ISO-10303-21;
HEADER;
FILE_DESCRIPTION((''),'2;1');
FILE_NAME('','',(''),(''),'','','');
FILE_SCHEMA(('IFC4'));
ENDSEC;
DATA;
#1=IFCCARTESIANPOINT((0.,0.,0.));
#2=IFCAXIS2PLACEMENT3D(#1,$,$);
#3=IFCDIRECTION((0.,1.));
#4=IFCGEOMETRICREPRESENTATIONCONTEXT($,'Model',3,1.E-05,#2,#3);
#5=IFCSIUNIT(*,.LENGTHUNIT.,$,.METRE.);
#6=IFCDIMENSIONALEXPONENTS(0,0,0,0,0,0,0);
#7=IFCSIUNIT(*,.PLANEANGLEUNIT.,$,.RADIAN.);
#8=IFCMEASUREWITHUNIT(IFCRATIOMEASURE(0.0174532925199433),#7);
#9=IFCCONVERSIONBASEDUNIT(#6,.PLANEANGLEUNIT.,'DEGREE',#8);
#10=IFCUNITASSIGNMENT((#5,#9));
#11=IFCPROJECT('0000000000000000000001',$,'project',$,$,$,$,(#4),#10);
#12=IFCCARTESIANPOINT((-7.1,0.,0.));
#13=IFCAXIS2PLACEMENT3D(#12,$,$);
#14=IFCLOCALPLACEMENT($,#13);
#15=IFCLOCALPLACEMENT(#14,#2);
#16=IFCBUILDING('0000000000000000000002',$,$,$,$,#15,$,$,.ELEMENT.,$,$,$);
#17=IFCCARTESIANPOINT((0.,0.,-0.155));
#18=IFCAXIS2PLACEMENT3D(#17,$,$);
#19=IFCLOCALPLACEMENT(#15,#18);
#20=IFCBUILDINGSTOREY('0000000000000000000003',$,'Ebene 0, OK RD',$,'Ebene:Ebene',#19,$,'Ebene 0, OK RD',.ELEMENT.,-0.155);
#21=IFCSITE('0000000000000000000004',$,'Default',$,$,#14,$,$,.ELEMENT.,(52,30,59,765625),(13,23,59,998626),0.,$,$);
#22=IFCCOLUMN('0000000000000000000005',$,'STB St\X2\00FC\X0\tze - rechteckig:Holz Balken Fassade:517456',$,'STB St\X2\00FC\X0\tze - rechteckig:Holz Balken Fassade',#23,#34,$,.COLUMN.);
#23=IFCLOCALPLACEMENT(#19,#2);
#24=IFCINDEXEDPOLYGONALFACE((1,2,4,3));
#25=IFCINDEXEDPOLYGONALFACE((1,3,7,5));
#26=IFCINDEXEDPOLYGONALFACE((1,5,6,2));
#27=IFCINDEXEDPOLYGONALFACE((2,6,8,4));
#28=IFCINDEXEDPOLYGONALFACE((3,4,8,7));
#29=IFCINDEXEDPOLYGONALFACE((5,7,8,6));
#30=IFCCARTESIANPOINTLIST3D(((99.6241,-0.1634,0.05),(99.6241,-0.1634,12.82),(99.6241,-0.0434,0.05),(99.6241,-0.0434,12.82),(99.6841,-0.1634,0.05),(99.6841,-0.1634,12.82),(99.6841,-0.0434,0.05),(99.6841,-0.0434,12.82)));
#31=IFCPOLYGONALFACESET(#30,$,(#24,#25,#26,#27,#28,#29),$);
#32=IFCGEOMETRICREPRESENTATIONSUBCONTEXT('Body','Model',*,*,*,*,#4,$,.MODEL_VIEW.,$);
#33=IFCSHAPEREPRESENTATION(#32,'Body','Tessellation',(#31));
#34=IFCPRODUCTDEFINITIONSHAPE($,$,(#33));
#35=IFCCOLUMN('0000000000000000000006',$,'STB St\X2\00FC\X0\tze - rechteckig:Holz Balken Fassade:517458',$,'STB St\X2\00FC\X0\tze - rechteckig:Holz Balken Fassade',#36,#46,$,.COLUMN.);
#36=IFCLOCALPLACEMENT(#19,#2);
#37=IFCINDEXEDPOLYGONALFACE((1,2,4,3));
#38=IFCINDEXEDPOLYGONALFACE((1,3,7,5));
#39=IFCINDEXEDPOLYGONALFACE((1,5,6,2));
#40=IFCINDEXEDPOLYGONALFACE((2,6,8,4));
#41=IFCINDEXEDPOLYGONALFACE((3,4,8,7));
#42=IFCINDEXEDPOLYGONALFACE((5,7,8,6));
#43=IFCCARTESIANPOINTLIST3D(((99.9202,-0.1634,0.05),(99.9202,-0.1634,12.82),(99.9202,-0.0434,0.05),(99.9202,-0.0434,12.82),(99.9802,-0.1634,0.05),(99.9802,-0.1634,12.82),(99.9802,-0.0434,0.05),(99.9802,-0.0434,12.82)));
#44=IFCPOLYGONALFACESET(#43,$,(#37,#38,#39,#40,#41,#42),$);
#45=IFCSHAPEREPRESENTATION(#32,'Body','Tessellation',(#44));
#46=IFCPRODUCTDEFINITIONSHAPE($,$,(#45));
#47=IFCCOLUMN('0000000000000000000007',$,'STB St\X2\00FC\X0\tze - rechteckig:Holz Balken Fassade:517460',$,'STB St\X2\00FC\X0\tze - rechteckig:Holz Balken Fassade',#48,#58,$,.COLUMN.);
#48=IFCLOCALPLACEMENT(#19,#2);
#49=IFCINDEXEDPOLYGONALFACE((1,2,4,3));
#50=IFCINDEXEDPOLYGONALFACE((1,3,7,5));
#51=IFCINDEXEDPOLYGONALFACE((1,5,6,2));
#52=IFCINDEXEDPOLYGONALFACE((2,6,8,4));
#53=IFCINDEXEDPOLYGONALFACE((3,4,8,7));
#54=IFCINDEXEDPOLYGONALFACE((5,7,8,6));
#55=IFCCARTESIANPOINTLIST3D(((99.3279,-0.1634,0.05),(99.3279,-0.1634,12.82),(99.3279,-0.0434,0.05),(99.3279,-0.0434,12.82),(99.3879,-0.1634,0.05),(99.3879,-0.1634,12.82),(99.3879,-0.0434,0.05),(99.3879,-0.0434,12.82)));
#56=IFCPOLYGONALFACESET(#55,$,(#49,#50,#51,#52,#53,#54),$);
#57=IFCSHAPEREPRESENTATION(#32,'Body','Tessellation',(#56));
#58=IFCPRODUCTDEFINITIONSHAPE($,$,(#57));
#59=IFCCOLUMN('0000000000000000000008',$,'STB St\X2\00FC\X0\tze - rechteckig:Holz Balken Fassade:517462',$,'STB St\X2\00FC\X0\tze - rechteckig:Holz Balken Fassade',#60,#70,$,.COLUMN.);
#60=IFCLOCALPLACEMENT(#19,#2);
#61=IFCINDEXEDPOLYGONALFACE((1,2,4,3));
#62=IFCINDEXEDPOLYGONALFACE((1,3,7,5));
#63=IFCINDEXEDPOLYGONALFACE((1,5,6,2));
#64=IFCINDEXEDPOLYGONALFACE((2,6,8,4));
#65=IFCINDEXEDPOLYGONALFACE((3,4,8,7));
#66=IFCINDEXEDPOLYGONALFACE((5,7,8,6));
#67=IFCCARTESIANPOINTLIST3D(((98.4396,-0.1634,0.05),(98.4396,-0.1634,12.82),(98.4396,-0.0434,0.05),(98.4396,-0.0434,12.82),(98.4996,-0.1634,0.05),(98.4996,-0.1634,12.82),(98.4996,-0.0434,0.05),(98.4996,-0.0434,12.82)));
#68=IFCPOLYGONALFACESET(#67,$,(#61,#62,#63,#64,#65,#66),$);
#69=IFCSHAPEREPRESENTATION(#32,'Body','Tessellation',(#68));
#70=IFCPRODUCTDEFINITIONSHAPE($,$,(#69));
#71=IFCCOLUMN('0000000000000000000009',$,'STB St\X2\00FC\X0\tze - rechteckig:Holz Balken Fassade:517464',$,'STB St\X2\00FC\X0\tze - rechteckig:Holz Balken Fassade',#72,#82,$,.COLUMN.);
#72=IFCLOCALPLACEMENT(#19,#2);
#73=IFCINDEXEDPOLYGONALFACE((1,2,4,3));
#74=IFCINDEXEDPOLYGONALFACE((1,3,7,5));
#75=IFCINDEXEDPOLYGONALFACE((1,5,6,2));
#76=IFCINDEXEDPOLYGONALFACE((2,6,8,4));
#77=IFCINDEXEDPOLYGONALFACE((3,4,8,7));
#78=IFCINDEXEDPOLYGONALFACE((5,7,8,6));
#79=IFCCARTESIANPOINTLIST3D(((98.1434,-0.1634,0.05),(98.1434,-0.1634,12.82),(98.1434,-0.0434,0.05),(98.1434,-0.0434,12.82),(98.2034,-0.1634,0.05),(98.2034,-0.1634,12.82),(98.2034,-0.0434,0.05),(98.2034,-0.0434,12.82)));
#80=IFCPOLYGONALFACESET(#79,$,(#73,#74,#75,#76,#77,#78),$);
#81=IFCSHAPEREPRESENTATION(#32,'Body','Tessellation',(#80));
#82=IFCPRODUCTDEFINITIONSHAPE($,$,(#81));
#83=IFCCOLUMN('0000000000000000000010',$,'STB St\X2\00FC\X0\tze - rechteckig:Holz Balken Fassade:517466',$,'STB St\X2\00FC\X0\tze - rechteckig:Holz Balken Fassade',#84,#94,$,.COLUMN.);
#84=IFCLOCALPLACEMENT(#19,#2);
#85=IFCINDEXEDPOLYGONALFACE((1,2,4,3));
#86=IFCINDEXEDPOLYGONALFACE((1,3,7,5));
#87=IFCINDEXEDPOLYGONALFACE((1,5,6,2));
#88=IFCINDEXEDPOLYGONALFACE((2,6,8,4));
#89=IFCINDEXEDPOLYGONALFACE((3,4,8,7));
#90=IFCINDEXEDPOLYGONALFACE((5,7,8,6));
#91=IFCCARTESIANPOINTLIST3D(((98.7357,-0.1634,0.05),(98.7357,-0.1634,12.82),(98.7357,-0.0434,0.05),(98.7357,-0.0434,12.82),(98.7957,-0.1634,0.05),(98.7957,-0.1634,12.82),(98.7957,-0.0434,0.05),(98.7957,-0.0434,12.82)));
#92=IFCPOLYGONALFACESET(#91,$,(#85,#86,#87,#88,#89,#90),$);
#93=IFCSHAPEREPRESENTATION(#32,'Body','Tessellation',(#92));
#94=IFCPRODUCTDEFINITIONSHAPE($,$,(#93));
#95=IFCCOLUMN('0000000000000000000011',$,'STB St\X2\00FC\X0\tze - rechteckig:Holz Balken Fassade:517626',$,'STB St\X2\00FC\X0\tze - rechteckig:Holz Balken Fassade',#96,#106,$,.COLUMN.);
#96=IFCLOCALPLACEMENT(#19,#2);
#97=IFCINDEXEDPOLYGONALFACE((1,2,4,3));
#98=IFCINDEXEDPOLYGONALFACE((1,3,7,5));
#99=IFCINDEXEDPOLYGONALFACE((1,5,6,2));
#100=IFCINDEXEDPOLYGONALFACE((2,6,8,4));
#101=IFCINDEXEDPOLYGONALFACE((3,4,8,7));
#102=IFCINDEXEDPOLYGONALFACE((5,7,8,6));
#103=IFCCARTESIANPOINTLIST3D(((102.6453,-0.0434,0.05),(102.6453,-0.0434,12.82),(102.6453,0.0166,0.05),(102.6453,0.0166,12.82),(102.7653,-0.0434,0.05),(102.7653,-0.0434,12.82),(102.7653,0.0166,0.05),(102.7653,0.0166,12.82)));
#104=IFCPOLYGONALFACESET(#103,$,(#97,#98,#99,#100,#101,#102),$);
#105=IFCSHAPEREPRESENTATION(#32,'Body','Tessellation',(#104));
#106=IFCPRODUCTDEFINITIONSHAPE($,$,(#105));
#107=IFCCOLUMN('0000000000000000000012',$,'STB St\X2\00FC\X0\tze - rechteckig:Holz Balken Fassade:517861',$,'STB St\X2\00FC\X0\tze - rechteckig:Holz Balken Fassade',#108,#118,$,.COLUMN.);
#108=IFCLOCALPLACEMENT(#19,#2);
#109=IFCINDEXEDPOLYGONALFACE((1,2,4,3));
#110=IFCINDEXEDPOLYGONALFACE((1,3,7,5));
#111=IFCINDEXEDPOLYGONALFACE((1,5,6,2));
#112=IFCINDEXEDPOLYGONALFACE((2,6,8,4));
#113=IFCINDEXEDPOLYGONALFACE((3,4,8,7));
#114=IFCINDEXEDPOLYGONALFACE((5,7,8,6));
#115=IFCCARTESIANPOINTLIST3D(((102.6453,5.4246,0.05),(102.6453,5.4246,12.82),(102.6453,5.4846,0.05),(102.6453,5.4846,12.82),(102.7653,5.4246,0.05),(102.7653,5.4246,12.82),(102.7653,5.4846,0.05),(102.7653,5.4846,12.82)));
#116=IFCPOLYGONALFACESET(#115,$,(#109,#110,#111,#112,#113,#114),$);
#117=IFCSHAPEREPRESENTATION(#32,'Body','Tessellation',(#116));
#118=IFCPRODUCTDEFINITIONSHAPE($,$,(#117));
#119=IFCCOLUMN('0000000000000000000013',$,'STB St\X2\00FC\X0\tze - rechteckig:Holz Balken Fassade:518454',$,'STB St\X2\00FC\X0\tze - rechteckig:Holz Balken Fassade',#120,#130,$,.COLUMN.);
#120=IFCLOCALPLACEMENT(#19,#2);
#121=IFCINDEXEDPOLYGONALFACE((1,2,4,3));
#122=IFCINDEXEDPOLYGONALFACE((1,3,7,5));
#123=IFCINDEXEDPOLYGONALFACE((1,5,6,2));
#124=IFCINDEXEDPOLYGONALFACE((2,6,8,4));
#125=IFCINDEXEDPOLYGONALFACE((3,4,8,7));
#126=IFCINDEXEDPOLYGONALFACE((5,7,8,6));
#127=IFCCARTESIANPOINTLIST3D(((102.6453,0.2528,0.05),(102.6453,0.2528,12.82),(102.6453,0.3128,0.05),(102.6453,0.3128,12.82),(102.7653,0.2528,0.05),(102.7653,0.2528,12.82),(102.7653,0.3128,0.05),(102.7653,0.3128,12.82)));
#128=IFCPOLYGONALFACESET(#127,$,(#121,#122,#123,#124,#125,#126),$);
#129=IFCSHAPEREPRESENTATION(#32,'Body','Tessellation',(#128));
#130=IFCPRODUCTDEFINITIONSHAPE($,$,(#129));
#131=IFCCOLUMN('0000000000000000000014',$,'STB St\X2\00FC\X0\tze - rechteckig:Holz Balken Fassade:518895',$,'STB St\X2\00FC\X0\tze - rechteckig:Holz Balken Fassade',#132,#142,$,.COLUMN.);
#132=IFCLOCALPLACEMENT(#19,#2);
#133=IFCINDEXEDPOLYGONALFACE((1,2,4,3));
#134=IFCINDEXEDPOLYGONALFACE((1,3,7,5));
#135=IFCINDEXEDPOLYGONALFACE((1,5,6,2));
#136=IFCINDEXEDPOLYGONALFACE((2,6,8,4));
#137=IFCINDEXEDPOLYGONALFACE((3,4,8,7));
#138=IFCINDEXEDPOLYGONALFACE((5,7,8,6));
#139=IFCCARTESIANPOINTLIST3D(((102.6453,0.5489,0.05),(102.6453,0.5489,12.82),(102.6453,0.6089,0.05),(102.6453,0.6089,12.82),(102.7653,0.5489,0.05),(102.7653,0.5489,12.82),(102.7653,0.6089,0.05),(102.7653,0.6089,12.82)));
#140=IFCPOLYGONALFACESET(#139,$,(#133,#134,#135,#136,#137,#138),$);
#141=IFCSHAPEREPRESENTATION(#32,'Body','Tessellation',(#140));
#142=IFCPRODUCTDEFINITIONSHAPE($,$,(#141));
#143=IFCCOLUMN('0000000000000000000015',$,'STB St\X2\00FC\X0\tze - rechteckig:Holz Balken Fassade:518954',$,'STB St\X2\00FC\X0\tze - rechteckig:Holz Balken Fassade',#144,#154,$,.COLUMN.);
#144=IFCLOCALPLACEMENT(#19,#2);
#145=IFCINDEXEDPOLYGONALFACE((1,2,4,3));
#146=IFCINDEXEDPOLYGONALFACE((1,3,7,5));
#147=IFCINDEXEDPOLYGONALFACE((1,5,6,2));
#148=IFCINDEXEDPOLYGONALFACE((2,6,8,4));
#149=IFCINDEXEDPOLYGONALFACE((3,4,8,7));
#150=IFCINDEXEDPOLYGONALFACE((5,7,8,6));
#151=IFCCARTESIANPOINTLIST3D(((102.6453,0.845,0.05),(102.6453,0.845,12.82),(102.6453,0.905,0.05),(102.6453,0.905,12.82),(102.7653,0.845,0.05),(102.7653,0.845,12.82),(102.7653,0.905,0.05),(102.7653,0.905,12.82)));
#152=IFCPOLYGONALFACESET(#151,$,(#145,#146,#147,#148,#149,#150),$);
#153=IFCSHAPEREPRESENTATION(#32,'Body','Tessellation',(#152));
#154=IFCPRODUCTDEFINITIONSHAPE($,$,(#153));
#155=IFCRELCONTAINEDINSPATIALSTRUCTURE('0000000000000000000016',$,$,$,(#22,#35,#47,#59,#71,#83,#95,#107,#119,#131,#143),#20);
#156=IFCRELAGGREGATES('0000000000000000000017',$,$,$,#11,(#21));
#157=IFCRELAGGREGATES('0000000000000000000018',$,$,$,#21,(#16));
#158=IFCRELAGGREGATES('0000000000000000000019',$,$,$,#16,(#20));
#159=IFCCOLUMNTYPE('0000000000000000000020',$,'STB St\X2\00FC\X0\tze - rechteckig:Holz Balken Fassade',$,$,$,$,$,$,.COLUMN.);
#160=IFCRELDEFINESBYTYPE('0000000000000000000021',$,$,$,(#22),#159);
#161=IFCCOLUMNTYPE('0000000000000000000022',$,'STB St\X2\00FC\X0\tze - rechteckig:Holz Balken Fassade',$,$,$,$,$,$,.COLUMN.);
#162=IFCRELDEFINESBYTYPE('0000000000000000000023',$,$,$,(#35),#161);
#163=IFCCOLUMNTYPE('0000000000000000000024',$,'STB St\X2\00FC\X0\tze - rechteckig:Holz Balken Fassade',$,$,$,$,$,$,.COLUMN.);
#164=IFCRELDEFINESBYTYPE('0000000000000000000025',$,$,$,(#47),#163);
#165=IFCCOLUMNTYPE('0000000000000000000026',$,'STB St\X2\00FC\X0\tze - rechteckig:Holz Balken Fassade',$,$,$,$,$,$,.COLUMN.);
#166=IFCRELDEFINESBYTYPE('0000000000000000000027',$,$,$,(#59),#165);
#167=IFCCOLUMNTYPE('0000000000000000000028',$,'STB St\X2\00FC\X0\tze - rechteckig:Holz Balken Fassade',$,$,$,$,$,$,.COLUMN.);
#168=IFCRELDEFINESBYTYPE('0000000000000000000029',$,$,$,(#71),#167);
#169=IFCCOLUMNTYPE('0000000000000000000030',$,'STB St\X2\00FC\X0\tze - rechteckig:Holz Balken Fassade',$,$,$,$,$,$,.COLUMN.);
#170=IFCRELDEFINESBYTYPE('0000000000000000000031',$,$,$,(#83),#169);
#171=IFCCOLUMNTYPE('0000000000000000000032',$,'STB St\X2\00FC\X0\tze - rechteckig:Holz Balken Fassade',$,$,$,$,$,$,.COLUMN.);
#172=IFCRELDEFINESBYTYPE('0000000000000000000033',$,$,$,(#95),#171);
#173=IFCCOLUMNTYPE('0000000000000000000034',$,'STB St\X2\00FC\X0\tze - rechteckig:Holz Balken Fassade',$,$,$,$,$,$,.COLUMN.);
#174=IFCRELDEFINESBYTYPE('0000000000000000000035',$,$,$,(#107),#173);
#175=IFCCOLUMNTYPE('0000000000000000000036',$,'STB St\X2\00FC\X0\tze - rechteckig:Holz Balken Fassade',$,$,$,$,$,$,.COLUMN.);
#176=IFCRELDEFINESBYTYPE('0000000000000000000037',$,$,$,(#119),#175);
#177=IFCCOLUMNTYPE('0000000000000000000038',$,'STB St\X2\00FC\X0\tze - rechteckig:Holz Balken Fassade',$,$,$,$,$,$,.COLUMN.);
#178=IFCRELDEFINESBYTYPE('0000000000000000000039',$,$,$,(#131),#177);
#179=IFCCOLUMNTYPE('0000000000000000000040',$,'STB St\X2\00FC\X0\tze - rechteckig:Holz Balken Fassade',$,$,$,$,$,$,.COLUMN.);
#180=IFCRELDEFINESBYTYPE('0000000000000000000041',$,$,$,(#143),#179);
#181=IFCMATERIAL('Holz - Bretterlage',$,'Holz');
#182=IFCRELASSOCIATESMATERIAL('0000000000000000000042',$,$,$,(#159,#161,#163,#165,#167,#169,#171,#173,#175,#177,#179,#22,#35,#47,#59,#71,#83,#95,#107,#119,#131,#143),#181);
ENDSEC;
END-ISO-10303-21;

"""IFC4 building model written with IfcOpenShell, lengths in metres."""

from ifc_helpers import new_model, entity, si_unit, converted_unit, direction, frame, frame_2d, origin, origin_2d_with_axis, place, context, subcontext, project, spatial, rectangle, extrude, source, transform, mapped, material, material_profile, profile_set, profile_usage, type_object, type_shapes, element, save


model = new_model("IFC4")

# Units and contexts
model_context = context("Model", 3, precision=1e-05, world=origin(), true_north=direction((0.0, 1.0)))
body_context = subcontext(model_context, "Body", "Model", "MODEL_VIEW")
ifc_project = project(units=[si_unit("LENGTHUNIT", "METRE"), converted_unit("PLANEANGLEUNIT", "DEGREE", entity("IfcRatioMeasure", 0.0174532925199433), si_unit("PLANEANGLEUNIT", "RADIAN"), dimensions=[0, 0, 0, 0, 0, 0, 0])], contexts=[model_context])

# Site, building, storey
site_placement = place(None, frame((-7.1, 0.0, 0.0)))
site = spatial("IfcSite", under=ifc_project, at=site_placement, Name="Default", CompositionType="ELEMENT", RefLatitude=(52, 30, 59, 765625), RefLongitude=(13, 23, 59, 998626), RefElevation=0.0)
building_placement = place(site_placement, origin())
building = spatial("IfcBuilding", under=site, at=building_placement, CompositionType="ELEMENT")
storey_placement = place(building_placement, frame((0.0, 0.0, -0.155)))
storey = spatial("IfcBuildingStorey", under=building, at=storey_placement, Name="Ebene 0, OK RD", ObjectType="Ebene:Ebene", LongName="Ebene 0, OK RD", CompositionType="ELEMENT", Elevation=-0.155)

# Columns
ifc_material = material(Name="Holz - Bretterlage", Category="Holz")
ifc_material_profile = material_profile(ifc_material, rectangle(XDim=0.12, YDim=0.06, at=frame_2d((0.0, 0.0), x_axis=(1.0, 0.0))), Name="Holz Balken Fassade")
ifc_profile_set = profile_set([ifc_material_profile], Name="Holz Balken Fassade")
ifc_profile_usage_1 = profile_usage(ifc_profile_set)
column_type_1 = type_object("IfcColumnType", Name="STB Stütze - rechteckig:Holz Balken Fassade", PredefinedType="COLUMN", material=ifc_profile_set)
shared_shape_1 = source(origin(), body_context, "Body", "SweptSolid", [
    extrude(rectangle(XDim=0.12, YDim=0.06, at=frame_2d((0.0, 0.0), x_axis=(1.0, 0.0))), frame((99.6541, -0.1034, -0.105), z_axis=(0.0, 0.0, 1.0), x_axis=(0.0, -1.0, 0.0)), (0.0, 0.0, 1.0), 12.77),
])
type_shapes(column_type_1, [shared_shape_1])
column_1_placement = place(storey_placement, frame((0.0, 0.0, 0.155)))
element("IfcColumn", 1, at=column_1_placement, inside=storey, type_object=column_type_1, material=ifc_profile_usage_1, Name="STB Stütze - rechteckig:Holz Balken Fassade:517456", ObjectType="STB Stütze - rechteckig:Holz Balken Fassade", PredefinedType="COLUMN", context=body_context, shape_type="MappedRepresentation", body=[
    mapped(shared_shape_1, transform((0.0, 0.0, 0.0), scale=1.0)),
])
ifc_profile_usage_2 = profile_usage(ifc_profile_set)
column_type_2 = type_object("IfcColumnType", Name="STB Stütze - rechteckig:Holz Balken Fassade", PredefinedType="COLUMN", material=ifc_profile_set)
shared_shape_2 = source(origin(), body_context, "Body", "SweptSolid", [
    extrude(rectangle(XDim=0.12, YDim=0.06, at=frame_2d((0.0, 0.0), x_axis=(1.0, 0.0))), frame((99.9502, -0.1034, -0.105), z_axis=(0.0, 0.0, 1.0), x_axis=(0.0, -1.0, 0.0)), (0.0, 0.0, 1.0), 12.77),
])
type_shapes(column_type_2, [shared_shape_2])
column_2_placement = place(storey_placement, frame((0.0, 0.0, 0.155)))
element("IfcColumn", 2, at=column_2_placement, inside=storey, type_object=column_type_2, material=ifc_profile_usage_2, Name="STB Stütze - rechteckig:Holz Balken Fassade:517458", ObjectType="STB Stütze - rechteckig:Holz Balken Fassade", PredefinedType="COLUMN", context=body_context, shape_type="MappedRepresentation", body=[
    mapped(shared_shape_2, transform((0.0, 0.0, 0.0), scale=1.0)),
])
ifc_profile_usage_3 = profile_usage(ifc_profile_set)
column_type_3 = type_object("IfcColumnType", Name="STB Stütze - rechteckig:Holz Balken Fassade", PredefinedType="COLUMN", material=ifc_profile_set)
shared_shape_3 = source(origin(), body_context, "Body", "SweptSolid", [
    extrude(rectangle(XDim=0.12, YDim=0.06, at=frame_2d((0.0, 0.0), x_axis=(1.0, 0.0))), frame((99.3579, -0.1034, -0.105), z_axis=(0.0, 0.0, 1.0), x_axis=(0.0, -1.0, 0.0)), (0.0, 0.0, 1.0), 12.77),
])
type_shapes(column_type_3, [shared_shape_3])
column_3_placement = place(storey_placement, frame((0.0, 0.0, 0.155)))
element("IfcColumn", 3, at=column_3_placement, inside=storey, type_object=column_type_3, material=ifc_profile_usage_3, Name="STB Stütze - rechteckig:Holz Balken Fassade:517460", ObjectType="STB Stütze - rechteckig:Holz Balken Fassade", PredefinedType="COLUMN", context=body_context, shape_type="MappedRepresentation", body=[
    mapped(shared_shape_3, transform((0.0, 0.0, 0.0), scale=1.0)),
])
ifc_profile_usage_4 = profile_usage(ifc_profile_set)
column_type_4 = type_object("IfcColumnType", Name="STB Stütze - rechteckig:Holz Balken Fassade", PredefinedType="COLUMN", material=ifc_profile_set)
shared_shape_4 = source(origin(), body_context, "Body", "SweptSolid", [
    extrude(rectangle(XDim=0.12, YDim=0.06, at=frame_2d((0.0, 0.0), x_axis=(1.0, 0.0))), frame((98.4696, -0.1034, -0.105), z_axis=(0.0, 0.0, 1.0), x_axis=(0.0, -1.0, 0.0)), (0.0, 0.0, 1.0), 12.77),
])
type_shapes(column_type_4, [shared_shape_4])
column_4_placement = place(storey_placement, frame((0.0, 0.0, 0.155)))
element("IfcColumn", 4, at=column_4_placement, inside=storey, type_object=column_type_4, material=ifc_profile_usage_4, Name="STB Stütze - rechteckig:Holz Balken Fassade:517462", ObjectType="STB Stütze - rechteckig:Holz Balken Fassade", PredefinedType="COLUMN", context=body_context, shape_type="MappedRepresentation", body=[
    mapped(shared_shape_4, transform((0.0, 0.0, 0.0), scale=1.0)),
])
ifc_profile_usage_5 = profile_usage(ifc_profile_set)
column_type_5 = type_object("IfcColumnType", Name="STB Stütze - rechteckig:Holz Balken Fassade", PredefinedType="COLUMN", material=ifc_profile_set)
shared_shape_5 = source(origin(), body_context, "Body", "SweptSolid", [
    extrude(rectangle(XDim=0.12, YDim=0.06, at=frame_2d((0.0, 0.0), x_axis=(1.0, 0.0))), frame((98.1734, -0.1034, -0.105), z_axis=(0.0, 0.0, 1.0), x_axis=(0.0, -1.0, 0.0)), (0.0, 0.0, 1.0), 12.77),
])
type_shapes(column_type_5, [shared_shape_5])
column_5_placement = place(storey_placement, frame((0.0, 0.0, 0.155)))
element("IfcColumn", 5, at=column_5_placement, inside=storey, type_object=column_type_5, material=ifc_profile_usage_5, Name="STB Stütze - rechteckig:Holz Balken Fassade:517464", ObjectType="STB Stütze - rechteckig:Holz Balken Fassade", PredefinedType="COLUMN", context=body_context, shape_type="MappedRepresentation", body=[
    mapped(shared_shape_5, transform((0.0, 0.0, 0.0), scale=1.0)),
])
ifc_profile_usage_6 = profile_usage(ifc_profile_set)
column_type_6 = type_object("IfcColumnType", Name="STB Stütze - rechteckig:Holz Balken Fassade", PredefinedType="COLUMN", material=ifc_profile_set)
shared_shape_6 = source(origin(), body_context, "Body", "SweptSolid", [
    extrude(rectangle(XDim=0.12, YDim=0.06, at=frame_2d((0.0, 0.0), x_axis=(1.0, 0.0))), frame((98.7657, -0.1034, -0.105), z_axis=(0.0, 0.0, 1.0), x_axis=(0.0, -1.0, 0.0)), (0.0, 0.0, 1.0), 12.77),
])
type_shapes(column_type_6, [shared_shape_6])
column_6_placement = place(storey_placement, frame((0.0, 0.0, 0.155)))
element("IfcColumn", 6, at=column_6_placement, inside=storey, type_object=column_type_6, material=ifc_profile_usage_6, Name="STB Stütze - rechteckig:Holz Balken Fassade:517466", ObjectType="STB Stütze - rechteckig:Holz Balken Fassade", PredefinedType="COLUMN", context=body_context, shape_type="MappedRepresentation", body=[
    mapped(shared_shape_6, transform((0.0, 0.0, 0.0), scale=1.0)),
])
ifc_profile_usage_7 = profile_usage(ifc_profile_set)
column_type_7 = type_object("IfcColumnType", Name="STB Stütze - rechteckig:Holz Balken Fassade", PredefinedType="COLUMN", material=ifc_profile_set)
shared_shape_7 = source(origin(), body_context, "Body", "SweptSolid", [
    extrude(rectangle(XDim=0.06, YDim=0.12, at=frame_2d((0.0, 0.0), x_axis=(1.0, 0.0))), frame((102.7053, -0.0134, -0.105), z_axis=(0.0, 0.0, 1.0), x_axis=(0.0, -1.0, 0.0)), (0.0, 0.0, 1.0), 12.77),
])
type_shapes(column_type_7, [shared_shape_7])
column_7_placement = place(storey_placement, frame((0.0, 0.0, 0.155)))
element("IfcColumn", 7, at=column_7_placement, inside=storey, type_object=column_type_7, material=ifc_profile_usage_7, Name="STB Stütze - rechteckig:Holz Balken Fassade:517626", ObjectType="STB Stütze - rechteckig:Holz Balken Fassade", PredefinedType="COLUMN", context=body_context, shape_type="MappedRepresentation", body=[
    mapped(shared_shape_7, transform((0.0, 0.0, 0.0), scale=1.0)),
])
ifc_profile_usage_8 = profile_usage(ifc_profile_set)
column_type_8 = type_object("IfcColumnType", Name="STB Stütze - rechteckig:Holz Balken Fassade", PredefinedType="COLUMN", material=ifc_profile_set)
shared_shape_8 = source(origin(), body_context, "Body", "SweptSolid", [
    extrude(rectangle(XDim=0.06, YDim=0.12, at=origin_2d_with_axis()), frame((102.7053, 5.4546, -0.105), z_axis=(0.0, 0.0, 1.0), x_axis=(0.0, -1.0, 0.0)), (0.0, 0.0, 1.0), 12.77),
])
type_shapes(column_type_8, [shared_shape_8])
column_8_placement = place(storey_placement, frame((0.0, 0.0, 0.155)))
element("IfcColumn", 8, at=column_8_placement, inside=storey, type_object=column_type_8, material=ifc_profile_usage_8, Name="STB Stütze - rechteckig:Holz Balken Fassade:517861", ObjectType="STB Stütze - rechteckig:Holz Balken Fassade", PredefinedType="COLUMN", context=body_context, shape_type="MappedRepresentation", body=[
    mapped(shared_shape_8, transform((0.0, 0.0, 0.0), scale=1.0)),
])
ifc_profile_usage_9 = profile_usage(ifc_profile_set)
column_type_9 = type_object("IfcColumnType", Name="STB Stütze - rechteckig:Holz Balken Fassade", PredefinedType="COLUMN", material=ifc_profile_set)
shared_shape_9 = source(origin(), body_context, "Body", "SweptSolid", [
    extrude(rectangle(XDim=0.06, YDim=0.12, at=frame_2d((0.0, 0.0), x_axis=(1.0, 0.0))), frame((102.7053, 0.2828, -0.105), z_axis=(0.0, 0.0, 1.0), x_axis=(0.0, -1.0, 0.0)), (0.0, 0.0, 1.0), 12.77),
])
type_shapes(column_type_9, [shared_shape_9])
column_9_placement = place(storey_placement, frame((0.0, 0.0, 0.155)))
element("IfcColumn", 9, at=column_9_placement, inside=storey, type_object=column_type_9, material=ifc_profile_usage_9, Name="STB Stütze - rechteckig:Holz Balken Fassade:518454", ObjectType="STB Stütze - rechteckig:Holz Balken Fassade", PredefinedType="COLUMN", context=body_context, shape_type="MappedRepresentation", body=[
    mapped(shared_shape_9, transform((0.0, 0.0, 0.0), scale=1.0)),
])
ifc_profile_usage_10 = profile_usage(ifc_profile_set)
column_type_10 = type_object("IfcColumnType", Name="STB Stütze - rechteckig:Holz Balken Fassade", PredefinedType="COLUMN", material=ifc_profile_set)
shared_shape_10 = source(origin(), body_context, "Body", "SweptSolid", [
    extrude(rectangle(XDim=0.06, YDim=0.12, at=frame_2d((0.0, 0.0), x_axis=(1.0, 0.0))), frame((102.7053, 0.5789, -0.105), z_axis=(0.0, 0.0, 1.0), x_axis=(0.0, -1.0, 0.0)), (0.0, 0.0, 1.0), 12.77),
])
type_shapes(column_type_10, [shared_shape_10])
column_10_placement = place(storey_placement, frame((0.0, 0.0, 0.155)))
element("IfcColumn", 10, at=column_10_placement, inside=storey, type_object=column_type_10, material=ifc_profile_usage_10, Name="STB Stütze - rechteckig:Holz Balken Fassade:518895", ObjectType="STB Stütze - rechteckig:Holz Balken Fassade", PredefinedType="COLUMN", context=body_context, shape_type="MappedRepresentation", body=[
    mapped(shared_shape_10, transform((0.0, 0.0, 0.0), scale=1.0)),
])
ifc_profile_usage_11 = profile_usage(ifc_profile_set)
column_type_11 = type_object("IfcColumnType", Name="STB Stütze - rechteckig:Holz Balken Fassade", PredefinedType="COLUMN", material=ifc_profile_set)
shared_shape_11 = source(origin(), body_context, "Body", "SweptSolid", [
    extrude(rectangle(XDim=0.06, YDim=0.12, at=origin_2d_with_axis()), frame((102.7053, 0.875, -0.105), z_axis=(0.0, 0.0, 1.0), x_axis=(0.0, -1.0, 0.0)), (0.0, 0.0, 1.0), 12.77),
])
type_shapes(column_type_11, [shared_shape_11])
column_11_placement = place(storey_placement, frame((0.0, 0.0, 0.155)))
element("IfcColumn", 11, at=column_11_placement, inside=storey, type_object=column_type_11, material=ifc_profile_usage_11, Name="STB Stütze - rechteckig:Holz Balken Fassade:518954", ObjectType="STB Stütze - rechteckig:Holz Balken Fassade", PredefinedType="COLUMN", context=body_context, shape_type="MappedRepresentation", body=[
    mapped(shared_shape_11, transform((0.0, 0.0, 0.0), scale=1.0)),
])

save(model, "model.ifc")
